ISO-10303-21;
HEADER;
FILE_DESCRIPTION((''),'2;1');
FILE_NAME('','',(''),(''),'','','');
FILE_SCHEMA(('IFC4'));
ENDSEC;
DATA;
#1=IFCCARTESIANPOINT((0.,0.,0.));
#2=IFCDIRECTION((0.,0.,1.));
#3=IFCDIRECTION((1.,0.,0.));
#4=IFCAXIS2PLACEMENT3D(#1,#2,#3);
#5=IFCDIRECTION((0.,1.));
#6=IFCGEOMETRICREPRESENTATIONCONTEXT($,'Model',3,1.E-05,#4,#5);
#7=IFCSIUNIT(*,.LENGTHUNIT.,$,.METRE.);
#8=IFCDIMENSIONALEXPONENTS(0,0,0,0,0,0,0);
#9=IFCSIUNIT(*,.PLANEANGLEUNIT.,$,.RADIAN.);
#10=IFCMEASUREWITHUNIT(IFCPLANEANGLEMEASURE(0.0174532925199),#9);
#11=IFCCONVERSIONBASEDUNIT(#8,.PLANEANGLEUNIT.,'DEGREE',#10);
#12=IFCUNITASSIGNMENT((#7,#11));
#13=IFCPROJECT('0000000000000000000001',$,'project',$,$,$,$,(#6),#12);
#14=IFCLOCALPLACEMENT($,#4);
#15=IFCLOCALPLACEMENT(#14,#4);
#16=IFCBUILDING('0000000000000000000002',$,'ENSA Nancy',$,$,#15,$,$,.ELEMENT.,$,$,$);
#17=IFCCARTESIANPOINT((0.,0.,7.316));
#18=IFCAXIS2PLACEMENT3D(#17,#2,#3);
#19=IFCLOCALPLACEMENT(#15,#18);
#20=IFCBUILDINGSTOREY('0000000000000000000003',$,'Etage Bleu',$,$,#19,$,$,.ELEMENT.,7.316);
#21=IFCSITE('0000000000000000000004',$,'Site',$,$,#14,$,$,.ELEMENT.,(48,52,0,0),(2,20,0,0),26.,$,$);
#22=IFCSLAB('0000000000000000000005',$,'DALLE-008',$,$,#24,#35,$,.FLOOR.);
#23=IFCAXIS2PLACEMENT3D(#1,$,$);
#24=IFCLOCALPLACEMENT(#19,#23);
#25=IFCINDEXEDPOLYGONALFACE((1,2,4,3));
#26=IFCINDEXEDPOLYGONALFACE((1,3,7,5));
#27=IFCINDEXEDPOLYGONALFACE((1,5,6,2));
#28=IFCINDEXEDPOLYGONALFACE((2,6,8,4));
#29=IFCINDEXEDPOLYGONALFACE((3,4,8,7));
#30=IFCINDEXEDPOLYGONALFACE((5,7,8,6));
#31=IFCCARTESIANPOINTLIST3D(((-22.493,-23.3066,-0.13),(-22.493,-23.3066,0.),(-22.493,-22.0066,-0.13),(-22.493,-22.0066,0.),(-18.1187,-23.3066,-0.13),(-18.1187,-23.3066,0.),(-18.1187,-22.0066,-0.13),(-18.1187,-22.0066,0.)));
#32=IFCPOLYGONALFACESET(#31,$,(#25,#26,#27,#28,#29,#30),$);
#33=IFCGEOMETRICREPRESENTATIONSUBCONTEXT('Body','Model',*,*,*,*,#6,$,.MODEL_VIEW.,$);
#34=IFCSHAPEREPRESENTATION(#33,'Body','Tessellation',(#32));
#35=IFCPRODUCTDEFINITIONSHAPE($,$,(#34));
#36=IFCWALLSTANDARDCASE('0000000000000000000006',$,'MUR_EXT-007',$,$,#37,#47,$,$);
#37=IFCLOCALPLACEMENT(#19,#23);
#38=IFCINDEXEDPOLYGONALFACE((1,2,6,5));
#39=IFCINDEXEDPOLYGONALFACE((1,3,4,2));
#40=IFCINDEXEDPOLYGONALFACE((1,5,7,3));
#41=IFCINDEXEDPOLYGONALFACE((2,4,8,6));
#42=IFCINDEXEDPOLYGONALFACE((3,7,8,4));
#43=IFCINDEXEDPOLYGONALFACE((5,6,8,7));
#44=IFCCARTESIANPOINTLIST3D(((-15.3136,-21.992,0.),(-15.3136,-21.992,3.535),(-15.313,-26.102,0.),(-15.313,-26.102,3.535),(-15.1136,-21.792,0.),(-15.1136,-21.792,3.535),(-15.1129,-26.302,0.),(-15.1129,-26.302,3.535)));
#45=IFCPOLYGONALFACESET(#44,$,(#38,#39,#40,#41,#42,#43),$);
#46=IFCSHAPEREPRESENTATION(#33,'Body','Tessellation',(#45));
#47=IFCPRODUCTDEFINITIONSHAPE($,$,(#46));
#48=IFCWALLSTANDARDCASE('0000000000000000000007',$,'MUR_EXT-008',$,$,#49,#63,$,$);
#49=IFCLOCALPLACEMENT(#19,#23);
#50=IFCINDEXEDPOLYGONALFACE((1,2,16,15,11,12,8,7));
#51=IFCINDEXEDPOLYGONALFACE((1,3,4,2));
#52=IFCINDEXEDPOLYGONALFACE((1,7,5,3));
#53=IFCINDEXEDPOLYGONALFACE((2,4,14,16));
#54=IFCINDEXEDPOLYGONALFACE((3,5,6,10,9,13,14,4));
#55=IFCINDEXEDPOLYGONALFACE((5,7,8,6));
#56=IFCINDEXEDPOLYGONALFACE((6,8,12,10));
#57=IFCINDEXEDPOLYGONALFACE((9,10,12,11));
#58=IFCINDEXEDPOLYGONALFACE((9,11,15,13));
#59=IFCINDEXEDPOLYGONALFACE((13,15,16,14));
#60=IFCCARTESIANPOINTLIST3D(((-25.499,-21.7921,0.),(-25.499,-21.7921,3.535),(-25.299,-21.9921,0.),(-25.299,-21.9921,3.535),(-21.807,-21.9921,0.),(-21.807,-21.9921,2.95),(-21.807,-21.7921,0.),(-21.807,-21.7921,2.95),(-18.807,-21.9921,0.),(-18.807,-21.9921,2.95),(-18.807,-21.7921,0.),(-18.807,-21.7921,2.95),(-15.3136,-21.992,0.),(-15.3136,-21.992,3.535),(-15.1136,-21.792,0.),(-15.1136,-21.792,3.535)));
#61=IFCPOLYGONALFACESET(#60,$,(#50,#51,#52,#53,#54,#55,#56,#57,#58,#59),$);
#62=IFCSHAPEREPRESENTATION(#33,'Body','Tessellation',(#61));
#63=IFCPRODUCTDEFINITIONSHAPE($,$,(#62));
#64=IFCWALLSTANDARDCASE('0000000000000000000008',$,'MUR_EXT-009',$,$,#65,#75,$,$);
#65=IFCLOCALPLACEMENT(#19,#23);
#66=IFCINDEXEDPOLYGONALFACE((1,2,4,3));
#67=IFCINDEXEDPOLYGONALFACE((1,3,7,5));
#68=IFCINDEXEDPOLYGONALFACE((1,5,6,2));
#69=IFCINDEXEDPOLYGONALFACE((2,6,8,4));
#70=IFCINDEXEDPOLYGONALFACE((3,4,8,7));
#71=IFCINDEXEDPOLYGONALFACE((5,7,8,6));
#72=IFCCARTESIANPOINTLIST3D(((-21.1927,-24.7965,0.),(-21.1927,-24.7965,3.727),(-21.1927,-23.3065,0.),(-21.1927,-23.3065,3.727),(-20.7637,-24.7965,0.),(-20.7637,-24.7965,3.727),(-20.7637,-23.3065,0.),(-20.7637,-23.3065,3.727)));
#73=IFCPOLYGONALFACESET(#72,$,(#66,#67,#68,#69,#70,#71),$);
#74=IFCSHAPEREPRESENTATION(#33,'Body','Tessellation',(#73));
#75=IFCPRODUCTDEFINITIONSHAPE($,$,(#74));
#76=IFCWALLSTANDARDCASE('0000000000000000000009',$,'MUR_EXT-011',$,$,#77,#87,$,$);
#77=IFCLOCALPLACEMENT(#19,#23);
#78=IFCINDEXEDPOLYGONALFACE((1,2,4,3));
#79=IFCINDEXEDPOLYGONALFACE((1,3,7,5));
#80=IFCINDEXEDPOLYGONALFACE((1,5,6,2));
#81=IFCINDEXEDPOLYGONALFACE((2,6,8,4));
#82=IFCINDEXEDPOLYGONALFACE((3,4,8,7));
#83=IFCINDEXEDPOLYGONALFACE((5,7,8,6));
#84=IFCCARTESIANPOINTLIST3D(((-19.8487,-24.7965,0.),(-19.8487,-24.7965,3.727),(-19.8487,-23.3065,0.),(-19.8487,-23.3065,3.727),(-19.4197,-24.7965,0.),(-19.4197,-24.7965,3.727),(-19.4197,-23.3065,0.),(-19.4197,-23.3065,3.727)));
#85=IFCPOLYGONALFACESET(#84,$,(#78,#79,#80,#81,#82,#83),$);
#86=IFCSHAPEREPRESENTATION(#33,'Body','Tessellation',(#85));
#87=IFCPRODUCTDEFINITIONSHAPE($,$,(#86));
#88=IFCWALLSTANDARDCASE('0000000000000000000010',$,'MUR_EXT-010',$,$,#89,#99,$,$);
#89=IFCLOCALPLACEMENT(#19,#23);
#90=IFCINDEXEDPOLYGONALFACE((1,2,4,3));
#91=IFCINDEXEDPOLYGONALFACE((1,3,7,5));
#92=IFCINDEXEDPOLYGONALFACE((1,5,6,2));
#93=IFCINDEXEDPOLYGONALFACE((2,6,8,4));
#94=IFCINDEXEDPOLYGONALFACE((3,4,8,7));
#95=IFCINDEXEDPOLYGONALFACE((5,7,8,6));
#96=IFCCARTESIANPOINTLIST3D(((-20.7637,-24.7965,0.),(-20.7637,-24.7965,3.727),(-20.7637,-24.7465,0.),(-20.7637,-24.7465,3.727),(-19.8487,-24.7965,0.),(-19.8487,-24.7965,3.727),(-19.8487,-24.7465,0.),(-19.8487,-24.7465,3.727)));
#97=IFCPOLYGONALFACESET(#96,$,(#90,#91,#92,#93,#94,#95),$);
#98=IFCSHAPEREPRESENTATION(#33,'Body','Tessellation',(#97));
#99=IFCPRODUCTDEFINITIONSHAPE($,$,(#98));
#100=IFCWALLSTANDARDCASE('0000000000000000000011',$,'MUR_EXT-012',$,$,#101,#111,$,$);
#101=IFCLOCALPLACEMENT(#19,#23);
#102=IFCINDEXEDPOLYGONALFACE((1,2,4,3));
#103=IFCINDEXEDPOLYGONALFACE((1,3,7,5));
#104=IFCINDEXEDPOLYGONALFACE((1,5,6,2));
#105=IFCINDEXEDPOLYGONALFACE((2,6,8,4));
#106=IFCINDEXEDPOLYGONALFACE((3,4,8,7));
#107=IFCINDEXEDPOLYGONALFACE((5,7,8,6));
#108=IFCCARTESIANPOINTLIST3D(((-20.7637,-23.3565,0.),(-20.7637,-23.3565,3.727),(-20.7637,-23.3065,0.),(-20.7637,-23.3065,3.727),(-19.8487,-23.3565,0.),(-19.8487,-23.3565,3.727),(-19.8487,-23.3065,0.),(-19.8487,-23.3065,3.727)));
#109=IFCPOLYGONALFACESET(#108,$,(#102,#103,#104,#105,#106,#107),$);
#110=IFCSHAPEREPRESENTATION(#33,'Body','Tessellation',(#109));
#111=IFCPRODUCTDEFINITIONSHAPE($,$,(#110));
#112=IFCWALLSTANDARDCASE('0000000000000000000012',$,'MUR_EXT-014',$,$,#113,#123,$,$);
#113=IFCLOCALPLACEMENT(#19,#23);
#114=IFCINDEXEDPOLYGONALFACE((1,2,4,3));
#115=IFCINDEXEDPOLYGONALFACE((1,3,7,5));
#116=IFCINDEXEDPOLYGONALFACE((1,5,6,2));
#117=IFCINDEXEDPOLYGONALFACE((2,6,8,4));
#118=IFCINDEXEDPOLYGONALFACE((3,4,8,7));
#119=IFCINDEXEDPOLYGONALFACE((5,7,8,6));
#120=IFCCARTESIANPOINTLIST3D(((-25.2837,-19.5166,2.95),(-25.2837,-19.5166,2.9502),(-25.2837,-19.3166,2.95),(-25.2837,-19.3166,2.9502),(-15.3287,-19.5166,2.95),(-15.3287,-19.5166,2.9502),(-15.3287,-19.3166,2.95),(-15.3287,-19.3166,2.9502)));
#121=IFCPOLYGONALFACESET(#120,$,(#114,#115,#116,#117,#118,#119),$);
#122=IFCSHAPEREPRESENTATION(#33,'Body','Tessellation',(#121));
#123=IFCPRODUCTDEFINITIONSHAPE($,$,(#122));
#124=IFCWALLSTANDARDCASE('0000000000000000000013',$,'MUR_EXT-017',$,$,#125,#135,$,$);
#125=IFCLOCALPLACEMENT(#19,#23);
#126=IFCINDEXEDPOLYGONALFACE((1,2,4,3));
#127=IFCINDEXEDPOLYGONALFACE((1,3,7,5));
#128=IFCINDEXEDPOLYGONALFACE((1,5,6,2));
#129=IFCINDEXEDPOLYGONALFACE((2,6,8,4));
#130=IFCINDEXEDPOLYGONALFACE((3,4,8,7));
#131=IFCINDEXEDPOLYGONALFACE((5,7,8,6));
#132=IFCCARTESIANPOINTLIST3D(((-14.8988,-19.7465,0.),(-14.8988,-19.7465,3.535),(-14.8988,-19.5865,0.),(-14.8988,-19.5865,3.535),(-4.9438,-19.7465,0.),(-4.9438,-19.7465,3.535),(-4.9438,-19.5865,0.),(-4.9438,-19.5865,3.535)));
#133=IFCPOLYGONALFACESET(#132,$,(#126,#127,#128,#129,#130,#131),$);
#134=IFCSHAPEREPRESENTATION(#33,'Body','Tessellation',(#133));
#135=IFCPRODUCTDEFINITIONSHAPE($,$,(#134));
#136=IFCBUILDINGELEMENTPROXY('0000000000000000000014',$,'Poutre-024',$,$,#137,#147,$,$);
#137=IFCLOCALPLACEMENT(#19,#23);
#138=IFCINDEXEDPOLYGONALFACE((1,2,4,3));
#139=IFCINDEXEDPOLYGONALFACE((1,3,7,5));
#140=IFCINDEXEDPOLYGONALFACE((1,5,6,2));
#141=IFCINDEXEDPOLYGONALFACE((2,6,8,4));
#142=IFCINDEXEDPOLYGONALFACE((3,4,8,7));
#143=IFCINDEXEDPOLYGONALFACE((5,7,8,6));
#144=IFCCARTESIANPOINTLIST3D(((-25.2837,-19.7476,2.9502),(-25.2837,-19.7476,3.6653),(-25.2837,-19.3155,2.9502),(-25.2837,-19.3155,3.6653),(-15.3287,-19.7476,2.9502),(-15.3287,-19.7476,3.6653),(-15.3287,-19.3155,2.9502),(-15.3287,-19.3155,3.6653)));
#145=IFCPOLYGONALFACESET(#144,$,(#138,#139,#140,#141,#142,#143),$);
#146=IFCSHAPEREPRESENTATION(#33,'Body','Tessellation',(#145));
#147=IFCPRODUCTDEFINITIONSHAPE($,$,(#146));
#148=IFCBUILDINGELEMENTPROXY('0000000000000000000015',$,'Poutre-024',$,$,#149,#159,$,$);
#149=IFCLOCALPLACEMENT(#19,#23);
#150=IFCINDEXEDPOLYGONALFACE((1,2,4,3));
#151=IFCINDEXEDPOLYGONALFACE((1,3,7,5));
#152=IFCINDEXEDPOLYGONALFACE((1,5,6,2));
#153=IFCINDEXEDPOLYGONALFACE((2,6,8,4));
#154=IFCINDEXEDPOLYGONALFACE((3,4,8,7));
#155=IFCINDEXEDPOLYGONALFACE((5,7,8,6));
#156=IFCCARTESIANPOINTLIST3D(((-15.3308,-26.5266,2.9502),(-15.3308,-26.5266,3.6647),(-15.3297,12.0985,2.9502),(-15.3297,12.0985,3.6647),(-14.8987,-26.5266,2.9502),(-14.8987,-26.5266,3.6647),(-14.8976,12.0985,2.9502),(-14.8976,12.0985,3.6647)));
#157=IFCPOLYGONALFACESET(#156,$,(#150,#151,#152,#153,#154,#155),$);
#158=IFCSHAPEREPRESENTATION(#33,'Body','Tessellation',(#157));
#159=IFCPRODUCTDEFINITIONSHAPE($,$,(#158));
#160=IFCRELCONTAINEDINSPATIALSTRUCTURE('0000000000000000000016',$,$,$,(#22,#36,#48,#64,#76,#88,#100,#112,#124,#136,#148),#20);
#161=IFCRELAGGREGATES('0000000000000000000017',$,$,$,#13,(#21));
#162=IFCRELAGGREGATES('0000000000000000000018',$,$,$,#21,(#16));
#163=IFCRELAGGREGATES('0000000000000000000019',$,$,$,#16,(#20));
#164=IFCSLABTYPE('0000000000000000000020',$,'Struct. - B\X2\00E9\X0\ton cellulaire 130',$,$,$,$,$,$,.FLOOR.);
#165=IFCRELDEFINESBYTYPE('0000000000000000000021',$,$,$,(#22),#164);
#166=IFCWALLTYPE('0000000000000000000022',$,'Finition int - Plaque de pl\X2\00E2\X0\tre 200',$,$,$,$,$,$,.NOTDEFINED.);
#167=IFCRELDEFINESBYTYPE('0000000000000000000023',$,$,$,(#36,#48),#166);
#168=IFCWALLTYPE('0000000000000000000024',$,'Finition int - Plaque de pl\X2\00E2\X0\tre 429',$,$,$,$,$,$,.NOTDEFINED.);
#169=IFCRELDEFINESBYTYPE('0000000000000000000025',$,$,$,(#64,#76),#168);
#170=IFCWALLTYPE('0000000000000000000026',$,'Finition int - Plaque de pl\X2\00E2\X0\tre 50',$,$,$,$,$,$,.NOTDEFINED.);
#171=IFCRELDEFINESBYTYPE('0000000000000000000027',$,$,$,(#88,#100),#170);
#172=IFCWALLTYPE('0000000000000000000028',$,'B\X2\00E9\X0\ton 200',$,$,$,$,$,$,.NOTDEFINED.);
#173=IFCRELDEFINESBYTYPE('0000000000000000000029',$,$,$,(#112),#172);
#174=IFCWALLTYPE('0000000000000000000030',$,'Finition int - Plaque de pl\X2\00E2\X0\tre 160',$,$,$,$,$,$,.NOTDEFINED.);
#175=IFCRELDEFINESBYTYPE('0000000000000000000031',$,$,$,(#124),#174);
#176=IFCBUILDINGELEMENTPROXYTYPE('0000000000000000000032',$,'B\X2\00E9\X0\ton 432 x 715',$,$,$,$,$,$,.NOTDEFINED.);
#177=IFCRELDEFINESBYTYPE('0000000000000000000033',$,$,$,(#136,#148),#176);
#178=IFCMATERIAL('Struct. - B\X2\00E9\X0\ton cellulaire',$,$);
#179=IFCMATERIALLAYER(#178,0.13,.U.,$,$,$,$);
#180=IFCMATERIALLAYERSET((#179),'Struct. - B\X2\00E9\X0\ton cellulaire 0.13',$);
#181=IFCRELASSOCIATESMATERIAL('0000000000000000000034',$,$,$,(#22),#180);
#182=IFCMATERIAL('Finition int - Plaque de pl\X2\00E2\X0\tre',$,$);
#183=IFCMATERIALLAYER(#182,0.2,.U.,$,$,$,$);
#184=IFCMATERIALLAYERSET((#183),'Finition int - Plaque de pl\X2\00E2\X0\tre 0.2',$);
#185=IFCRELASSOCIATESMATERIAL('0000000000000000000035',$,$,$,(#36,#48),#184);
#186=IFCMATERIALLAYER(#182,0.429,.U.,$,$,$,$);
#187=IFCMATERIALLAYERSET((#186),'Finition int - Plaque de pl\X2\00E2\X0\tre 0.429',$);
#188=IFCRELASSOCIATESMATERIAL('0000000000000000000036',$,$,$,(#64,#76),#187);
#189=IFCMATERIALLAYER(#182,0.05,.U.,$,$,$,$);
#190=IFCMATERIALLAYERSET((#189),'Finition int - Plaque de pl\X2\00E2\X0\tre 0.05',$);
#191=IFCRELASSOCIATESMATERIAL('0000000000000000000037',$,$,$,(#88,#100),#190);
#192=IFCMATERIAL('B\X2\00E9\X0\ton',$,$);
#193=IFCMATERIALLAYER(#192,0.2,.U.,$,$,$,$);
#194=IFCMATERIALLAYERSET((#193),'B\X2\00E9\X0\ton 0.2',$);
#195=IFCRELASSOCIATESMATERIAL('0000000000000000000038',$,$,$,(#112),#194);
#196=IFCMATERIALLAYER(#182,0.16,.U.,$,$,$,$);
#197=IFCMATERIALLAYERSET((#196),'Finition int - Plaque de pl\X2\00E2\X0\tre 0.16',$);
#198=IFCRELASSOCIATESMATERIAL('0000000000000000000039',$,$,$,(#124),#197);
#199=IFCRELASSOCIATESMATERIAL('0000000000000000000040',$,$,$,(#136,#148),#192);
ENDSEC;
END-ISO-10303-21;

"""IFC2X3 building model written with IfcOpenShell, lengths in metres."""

from ifc_helpers import new_model, entity, si_unit, converted_unit, direction, frame, frame_2d, origin_with_axes, origin_2d_with_axis, place, context, subcontext, project, spatial, polyline, rectangle, outline, extrude, material, layer, layer_set, layer_usage, type_object, element, save


model = new_model("IFC2X3")

# Units and contexts
model_context = context("Model", 3, precision=1e-05, world=origin_with_axes(), true_north=direction((0.0, 1.0)))
body_context = subcontext(model_context, "Body", "Model", "MODEL_VIEW")
ifc_project = project(units=[si_unit("LENGTHUNIT", "METRE"), converted_unit("PLANEANGLEUNIT", "DEGREE", entity("IfcPlaneAngleMeasure", 0.0174532925199), si_unit("PLANEANGLEUNIT", "RADIAN"), dimensions=[0, 0, 0, 0, 0, 0, 0])], contexts=[model_context])

# Site, building, storey
site_placement = place(None, origin_with_axes())
site = spatial("IfcSite", under=ifc_project, at=site_placement, Name="Site", CompositionType="ELEMENT", RefLatitude=(48, 52, 0, 0), RefLongitude=(2, 20, 0, 0), RefElevation=26.0)
building_placement = place(site_placement, origin_with_axes())
building = spatial("IfcBuilding", under=site, at=building_placement, Name="ENSA Nancy", CompositionType="ELEMENT")
storey_placement = place(building_placement, frame((0.0, 0.0, 7.316), z_axis=(0.0, 0.0, 1.0), x_axis=(1.0, 0.0, 0.0)))
storey = spatial("IfcBuildingStorey", under=building, at=storey_placement, Name="Etage Bleu", CompositionType="ELEMENT", Elevation=7.316)

# Slab
ifc_material_1 = material(Name="Struct. - Béton cellulaire")
ifc_layer_1 = layer(ifc_material_1, 0.13, ventilated="UNKNOWN")
ifc_layer_set_1 = layer_set([ifc_layer_1], Name="Struct. - Béton cellulaire 0.13")
ifc_layer_usage_1 = layer_usage(ifc_layer_set_1, "AXIS3", "NEGATIVE", 0.13)
slab_type = type_object("IfcSlabType", Name="Struct. - Béton cellulaire 130", PredefinedType="FLOOR")
slab_placement = place(storey_placement, frame((-22.493, -23.3066, 0.0), z_axis=(0.0, 0.0, 1.0), x_axis=(1.0, 0.0, 0.0)))
element("IfcSlab", 1, at=slab_placement, inside=storey, type_object=slab_type, material=ifc_layer_usage_1, Name="DALLE-008", PredefinedType="FLOOR", context=body_context, shape_type="SweptSolid", body=[
    extrude(outline(polyline([(0.0, 0.0), (4.3743, 0.0), (4.3743, 1.3), (0.0, 1.3), (0.0, 0.0)])), frame((0.0, 0.0, -0.13), z_axis=(0.0, 0.0, 1.0), x_axis=(1.0, 0.0, 0.0)), (0.0, 0.0, 1.0), 0.13),
])

# Wall
ifc_material_2 = material(Name="Finition int - Plaque de plâtre")
ifc_layer_2 = layer(ifc_material_2, 0.2, ventilated="UNKNOWN")
ifc_layer_set_2 = layer_set([ifc_layer_2], Name="Finition int - Plaque de plâtre 0.2")
ifc_layer_usage_2 = layer_usage(ifc_layer_set_2, "AXIS2", "POSITIVE", 0.0)
wall_type_1 = type_object("IfcWallType", Name="Finition int - Plaque de plâtre 200", PredefinedType="NOTDEFINED")
wall_1_placement = place(storey_placement, frame((-15.1129, -26.302, 0.0), z_axis=(0.0, 0.0, 1.0), x_axis=(-0.00015, 1.0, 0.0)))
element("IfcWallStandardCase", 2, at=wall_1_placement, inside=storey, type_object=wall_type_1, material=ifc_layer_usage_2, Name="MUR_EXT-007", context=body_context, shape_type="SweptSolid", body=[
    extrude(outline(polyline([(0.0, 0.0), (4.51, 0.0), (4.31, 0.2), (0.2, 0.2), (0.0, 0.0)])), origin_with_axes(), (0.0, 0.0, 1.0), 3.535),
])

# Wall, opening
ifc_layer_usage_3 = layer_usage(ifc_layer_set_2, "AXIS2", "POSITIVE", 0.0)
wall_2_placement = place(storey_placement, frame((-15.1136, -21.792, 0.0), z_axis=(0.0, 0.0, 1.0), x_axis=(-1.0, -0.000003, 0.0)))
wall_2 = element("IfcWallStandardCase", 3, at=wall_2_placement, inside=storey, type_object=wall_type_1, material=ifc_layer_usage_3, Name="MUR_EXT-008", context=body_context, shape_type="SweptSolid", body=[
    extrude(outline(polyline([(0.0, 0.0), (10.3854, 0.0), (10.1854, 0.2), (0.2, 0.2), (0.0, 0.0)])), origin_with_axes(), (0.0, 0.0, 1.0), 3.535),
])
opening_1_placement = place(wall_2_placement, frame((5.1934, 0.0, 0.0), z_axis=(0.0, 0.0, 1.0), x_axis=(1.0, 0.0, 0.0)))
element("IfcOpeningElement", 4, at=opening_1_placement, cuts=wall_2, context=body_context, shape_type="SweptSolid", body=[
    extrude(rectangle(XDim=3.0, YDim=2.95, at=origin_2d_with_axis()), frame((0.0, 0.2, 1.475), z_axis=(0.0, 1.0, 0.0), x_axis=(-1.0, 0.0, 0.0)), (0.0, 0.0, -1.0), 0.6),
])

# Walls
ifc_layer_3 = layer(ifc_material_2, 0.429, ventilated="UNKNOWN")
ifc_layer_set_3 = layer_set([ifc_layer_3], Name="Finition int - Plaque de plâtre 0.429")
ifc_layer_usage_4 = layer_usage(ifc_layer_set_3, "AXIS2", "POSITIVE", -0.429)
wall_type_2 = type_object("IfcWallType", Name="Finition int - Plaque de plâtre 429", PredefinedType="NOTDEFINED")
wall_3_placement = place(storey_placement, frame((-20.7637, -23.3065, 0.0), z_axis=(0.0, 0.0, 1.0), x_axis=(0.0, -1.0, 0.0)))
element("IfcWallStandardCase", 5, at=wall_3_placement, inside=storey, type_object=wall_type_2, material=ifc_layer_usage_4, Name="MUR_EXT-009", context=body_context, shape_type="SweptSolid", body=[
    extrude(outline(polyline([(0.0, -0.429), (1.49, -0.429), (1.49, 0.0), (0.0, 0.0), (0.0, -0.429)])), origin_with_axes(), (0.0, 0.0, 1.0), 3.727),
])
ifc_layer_usage_5 = layer_usage(ifc_layer_set_3, "AXIS2", "POSITIVE", -0.429)
wall_4_placement = place(storey_placement, frame((-19.8487, -24.7965, 0.0), z_axis=(0.0, 0.0, 1.0), x_axis=(0.0, 1.0, 0.0)))
element("IfcWallStandardCase", 6, at=wall_4_placement, inside=storey, type_object=wall_type_2, material=ifc_layer_usage_5, Name="MUR_EXT-011", context=body_context, shape_type="SweptSolid", body=[
    extrude(outline(polyline([(0.0, -0.429), (1.49, -0.429), (1.49, 0.0), (0.0, 0.0), (0.0, -0.429)])), origin_with_axes(), (0.0, 0.0, 1.0), 3.727),
])
ifc_layer_4 = layer(ifc_material_2, 0.05, ventilated="UNKNOWN")
ifc_layer_set_4 = layer_set([ifc_layer_4], Name="Finition int - Plaque de plâtre 0.05")
ifc_layer_usage_6 = layer_usage(ifc_layer_set_4, "AXIS2", "POSITIVE", -0.05)
wall_type_3 = type_object("IfcWallType", Name="Finition int - Plaque de plâtre 50", PredefinedType="NOTDEFINED")
wall_5_placement = place(storey_placement, frame((-20.7637, -24.7465, 0.0), z_axis=(0.0, 0.0, 1.0), x_axis=(1.0, 0.0, 0.0)))
element("IfcWallStandardCase", 7, at=wall_5_placement, inside=storey, type_object=wall_type_3, material=ifc_layer_usage_6, Name="MUR_EXT-010", context=body_context, shape_type="SweptSolid", body=[
    extrude(outline(polyline([(0.0, -0.05), (0.915, -0.05), (0.915, 0.0), (0.0, 0.0), (0.0, -0.05)])), origin_with_axes(), (0.0, 0.0, 1.0), 3.727),
])
ifc_layer_usage_7 = layer_usage(ifc_layer_set_4, "AXIS2", "POSITIVE", -0.05)
wall_6_placement = place(storey_placement, frame((-19.8487, -23.3565, 0.0), z_axis=(0.0, 0.0, 1.0), x_axis=(-1.0, 0.0, 0.0)))
element("IfcWallStandardCase", 8, at=wall_6_placement, inside=storey, type_object=wall_type_3, material=ifc_layer_usage_7, Name="MUR_EXT-012", context=body_context, shape_type="SweptSolid", body=[
    extrude(outline(polyline([(0.0, -0.05), (0.915, -0.05), (0.915, 0.0), (0.0, 0.0), (0.0, -0.05)])), origin_with_axes(), (0.0, 0.0, 1.0), 3.727),
])

# Wall, opening
ifc_material_3 = material(Name="Béton")
ifc_layer_5 = layer(ifc_material_3, 0.2, ventilated="UNKNOWN")
ifc_layer_set_5 = layer_set([ifc_layer_5], Name="Béton 0.2")
ifc_layer_usage_8 = layer_usage(ifc_layer_set_5, "AXIS2", "POSITIVE", -0.2)
wall_type_4 = type_object("IfcWallType", Name="Béton 200", PredefinedType="NOTDEFINED")
wall_7_placement = place(storey_placement, frame((-25.2837, -19.3166, 0.0), z_axis=(0.0, 0.0, 1.0), x_axis=(1.0, 0.0, 0.0)))
wall_7 = element("IfcWallStandardCase", 9, at=wall_7_placement, inside=storey, type_object=wall_type_4, material=ifc_layer_usage_8, Name="MUR_EXT-014", context=body_context, shape_type="SweptSolid", body=[
    extrude(outline(polyline([(0.0, -0.2), (9.955, -0.2), (9.955, 0.0), (0.0, 0.0), (0.0, -0.2)])), origin_with_axes(), (0.0, 0.0, 1.0), 2.9502),
])
opening_2_placement = place(wall_7_placement, frame((4.9775, 0.0, 0.0), z_axis=(0.0, 0.0, 1.0), x_axis=(1.0, 0.0, 0.0)))
element("IfcOpeningElement", 10, at=opening_2_placement, cuts=wall_7, context=body_context, shape_type="SweptSolid", body=[
    extrude(rectangle(XDim=9.955, YDim=2.95, at=origin_2d_with_axis()), frame((0.0, -0.2, 1.475), z_axis=(0.0, -1.0, 0.0), x_axis=(1.0, 0.0, 0.0)), (0.0, 0.0, -1.0), 0.6),
])

# Wall
ifc_layer_6 = layer(ifc_material_2, 0.16, ventilated="UNKNOWN")
ifc_layer_set_6 = layer_set([ifc_layer_6], Name="Finition int - Plaque de plâtre 0.16")
ifc_layer_usage_9 = layer_usage(ifc_layer_set_6, "AXIS2", "POSITIVE", -0.16)
wall_type_5 = type_object("IfcWallType", Name="Finition int - Plaque de plâtre 160", PredefinedType="NOTDEFINED")
wall_8_placement = place(storey_placement, frame((-14.8988, -19.5865, 0.0), z_axis=(0.0, 0.0, 1.0), x_axis=(1.0, 0.0, 0.0)))
element("IfcWallStandardCase", 11, at=wall_8_placement, inside=storey, type_object=wall_type_5, material=ifc_layer_usage_9, Name="MUR_EXT-017", context=body_context, shape_type="SweptSolid", body=[
    extrude(outline(polyline([(0.0, -0.16), (9.955, -0.16), (9.955, 0.0), (0.0, 0.0), (0.0, -0.16)])), origin_with_axes(), (0.0, 0.0, 1.0), 3.535),
])

# Building element proxies
building_element_proxy_type_1 = type_object("IfcBuildingElementProxyType", Name="Béton 432 x 715", PredefinedType="NOTDEFINED")
proxy_1_placement = place(storey_placement, frame((-15.3287, -19.5316, 3.6653), z_axis=(0.0, 0.0, 1.0), x_axis=(0.0, 1.0, 0.0)))
element("IfcBuildingElementProxy", 12, at=proxy_1_placement, inside=storey, type_object=building_element_proxy_type_1, material=ifc_material_3, Name="Poutre-024", context=body_context, shape_type="SweptSolid", body=[
    extrude(rectangle(XDim=0.7151, YDim=0.4321, at=frame_2d((-0.3575, 0.0), x_axis=(1.0, 0.0))), frame((0.0, 0.0, 0.0), z_axis=(0.0, 1.0, 0.0), x_axis=(0.0, 0.0, 1.0)), (0.0, 0.0, 1.0), 9.955),
])
proxy_2_placement = place(storey_placement, frame((-15.1147, -26.5266, 3.6647), z_axis=(0.0, 0.0, 1.0), x_axis=(1.0, -0.000027, 0.0)))
element("IfcBuildingElementProxy", 13, at=proxy_2_placement, inside=storey, type_object=building_element_proxy_type_1, material=ifc_material_3, Name="Poutre-024", context=body_context, shape_type="SweptSolid", body=[
    extrude(rectangle(XDim=0.7145, YDim=0.4321, at=frame_2d((-0.3573, 0.0), x_axis=(1.0, 0.0))), frame((0.0, 0.0, 0.0), z_axis=(0.0, 1.0, 0.0), x_axis=(0.0, 0.0, 1.0)), (0.0, 0.0, 1.0), 38.625),
])

save(model, "model.ifc")
